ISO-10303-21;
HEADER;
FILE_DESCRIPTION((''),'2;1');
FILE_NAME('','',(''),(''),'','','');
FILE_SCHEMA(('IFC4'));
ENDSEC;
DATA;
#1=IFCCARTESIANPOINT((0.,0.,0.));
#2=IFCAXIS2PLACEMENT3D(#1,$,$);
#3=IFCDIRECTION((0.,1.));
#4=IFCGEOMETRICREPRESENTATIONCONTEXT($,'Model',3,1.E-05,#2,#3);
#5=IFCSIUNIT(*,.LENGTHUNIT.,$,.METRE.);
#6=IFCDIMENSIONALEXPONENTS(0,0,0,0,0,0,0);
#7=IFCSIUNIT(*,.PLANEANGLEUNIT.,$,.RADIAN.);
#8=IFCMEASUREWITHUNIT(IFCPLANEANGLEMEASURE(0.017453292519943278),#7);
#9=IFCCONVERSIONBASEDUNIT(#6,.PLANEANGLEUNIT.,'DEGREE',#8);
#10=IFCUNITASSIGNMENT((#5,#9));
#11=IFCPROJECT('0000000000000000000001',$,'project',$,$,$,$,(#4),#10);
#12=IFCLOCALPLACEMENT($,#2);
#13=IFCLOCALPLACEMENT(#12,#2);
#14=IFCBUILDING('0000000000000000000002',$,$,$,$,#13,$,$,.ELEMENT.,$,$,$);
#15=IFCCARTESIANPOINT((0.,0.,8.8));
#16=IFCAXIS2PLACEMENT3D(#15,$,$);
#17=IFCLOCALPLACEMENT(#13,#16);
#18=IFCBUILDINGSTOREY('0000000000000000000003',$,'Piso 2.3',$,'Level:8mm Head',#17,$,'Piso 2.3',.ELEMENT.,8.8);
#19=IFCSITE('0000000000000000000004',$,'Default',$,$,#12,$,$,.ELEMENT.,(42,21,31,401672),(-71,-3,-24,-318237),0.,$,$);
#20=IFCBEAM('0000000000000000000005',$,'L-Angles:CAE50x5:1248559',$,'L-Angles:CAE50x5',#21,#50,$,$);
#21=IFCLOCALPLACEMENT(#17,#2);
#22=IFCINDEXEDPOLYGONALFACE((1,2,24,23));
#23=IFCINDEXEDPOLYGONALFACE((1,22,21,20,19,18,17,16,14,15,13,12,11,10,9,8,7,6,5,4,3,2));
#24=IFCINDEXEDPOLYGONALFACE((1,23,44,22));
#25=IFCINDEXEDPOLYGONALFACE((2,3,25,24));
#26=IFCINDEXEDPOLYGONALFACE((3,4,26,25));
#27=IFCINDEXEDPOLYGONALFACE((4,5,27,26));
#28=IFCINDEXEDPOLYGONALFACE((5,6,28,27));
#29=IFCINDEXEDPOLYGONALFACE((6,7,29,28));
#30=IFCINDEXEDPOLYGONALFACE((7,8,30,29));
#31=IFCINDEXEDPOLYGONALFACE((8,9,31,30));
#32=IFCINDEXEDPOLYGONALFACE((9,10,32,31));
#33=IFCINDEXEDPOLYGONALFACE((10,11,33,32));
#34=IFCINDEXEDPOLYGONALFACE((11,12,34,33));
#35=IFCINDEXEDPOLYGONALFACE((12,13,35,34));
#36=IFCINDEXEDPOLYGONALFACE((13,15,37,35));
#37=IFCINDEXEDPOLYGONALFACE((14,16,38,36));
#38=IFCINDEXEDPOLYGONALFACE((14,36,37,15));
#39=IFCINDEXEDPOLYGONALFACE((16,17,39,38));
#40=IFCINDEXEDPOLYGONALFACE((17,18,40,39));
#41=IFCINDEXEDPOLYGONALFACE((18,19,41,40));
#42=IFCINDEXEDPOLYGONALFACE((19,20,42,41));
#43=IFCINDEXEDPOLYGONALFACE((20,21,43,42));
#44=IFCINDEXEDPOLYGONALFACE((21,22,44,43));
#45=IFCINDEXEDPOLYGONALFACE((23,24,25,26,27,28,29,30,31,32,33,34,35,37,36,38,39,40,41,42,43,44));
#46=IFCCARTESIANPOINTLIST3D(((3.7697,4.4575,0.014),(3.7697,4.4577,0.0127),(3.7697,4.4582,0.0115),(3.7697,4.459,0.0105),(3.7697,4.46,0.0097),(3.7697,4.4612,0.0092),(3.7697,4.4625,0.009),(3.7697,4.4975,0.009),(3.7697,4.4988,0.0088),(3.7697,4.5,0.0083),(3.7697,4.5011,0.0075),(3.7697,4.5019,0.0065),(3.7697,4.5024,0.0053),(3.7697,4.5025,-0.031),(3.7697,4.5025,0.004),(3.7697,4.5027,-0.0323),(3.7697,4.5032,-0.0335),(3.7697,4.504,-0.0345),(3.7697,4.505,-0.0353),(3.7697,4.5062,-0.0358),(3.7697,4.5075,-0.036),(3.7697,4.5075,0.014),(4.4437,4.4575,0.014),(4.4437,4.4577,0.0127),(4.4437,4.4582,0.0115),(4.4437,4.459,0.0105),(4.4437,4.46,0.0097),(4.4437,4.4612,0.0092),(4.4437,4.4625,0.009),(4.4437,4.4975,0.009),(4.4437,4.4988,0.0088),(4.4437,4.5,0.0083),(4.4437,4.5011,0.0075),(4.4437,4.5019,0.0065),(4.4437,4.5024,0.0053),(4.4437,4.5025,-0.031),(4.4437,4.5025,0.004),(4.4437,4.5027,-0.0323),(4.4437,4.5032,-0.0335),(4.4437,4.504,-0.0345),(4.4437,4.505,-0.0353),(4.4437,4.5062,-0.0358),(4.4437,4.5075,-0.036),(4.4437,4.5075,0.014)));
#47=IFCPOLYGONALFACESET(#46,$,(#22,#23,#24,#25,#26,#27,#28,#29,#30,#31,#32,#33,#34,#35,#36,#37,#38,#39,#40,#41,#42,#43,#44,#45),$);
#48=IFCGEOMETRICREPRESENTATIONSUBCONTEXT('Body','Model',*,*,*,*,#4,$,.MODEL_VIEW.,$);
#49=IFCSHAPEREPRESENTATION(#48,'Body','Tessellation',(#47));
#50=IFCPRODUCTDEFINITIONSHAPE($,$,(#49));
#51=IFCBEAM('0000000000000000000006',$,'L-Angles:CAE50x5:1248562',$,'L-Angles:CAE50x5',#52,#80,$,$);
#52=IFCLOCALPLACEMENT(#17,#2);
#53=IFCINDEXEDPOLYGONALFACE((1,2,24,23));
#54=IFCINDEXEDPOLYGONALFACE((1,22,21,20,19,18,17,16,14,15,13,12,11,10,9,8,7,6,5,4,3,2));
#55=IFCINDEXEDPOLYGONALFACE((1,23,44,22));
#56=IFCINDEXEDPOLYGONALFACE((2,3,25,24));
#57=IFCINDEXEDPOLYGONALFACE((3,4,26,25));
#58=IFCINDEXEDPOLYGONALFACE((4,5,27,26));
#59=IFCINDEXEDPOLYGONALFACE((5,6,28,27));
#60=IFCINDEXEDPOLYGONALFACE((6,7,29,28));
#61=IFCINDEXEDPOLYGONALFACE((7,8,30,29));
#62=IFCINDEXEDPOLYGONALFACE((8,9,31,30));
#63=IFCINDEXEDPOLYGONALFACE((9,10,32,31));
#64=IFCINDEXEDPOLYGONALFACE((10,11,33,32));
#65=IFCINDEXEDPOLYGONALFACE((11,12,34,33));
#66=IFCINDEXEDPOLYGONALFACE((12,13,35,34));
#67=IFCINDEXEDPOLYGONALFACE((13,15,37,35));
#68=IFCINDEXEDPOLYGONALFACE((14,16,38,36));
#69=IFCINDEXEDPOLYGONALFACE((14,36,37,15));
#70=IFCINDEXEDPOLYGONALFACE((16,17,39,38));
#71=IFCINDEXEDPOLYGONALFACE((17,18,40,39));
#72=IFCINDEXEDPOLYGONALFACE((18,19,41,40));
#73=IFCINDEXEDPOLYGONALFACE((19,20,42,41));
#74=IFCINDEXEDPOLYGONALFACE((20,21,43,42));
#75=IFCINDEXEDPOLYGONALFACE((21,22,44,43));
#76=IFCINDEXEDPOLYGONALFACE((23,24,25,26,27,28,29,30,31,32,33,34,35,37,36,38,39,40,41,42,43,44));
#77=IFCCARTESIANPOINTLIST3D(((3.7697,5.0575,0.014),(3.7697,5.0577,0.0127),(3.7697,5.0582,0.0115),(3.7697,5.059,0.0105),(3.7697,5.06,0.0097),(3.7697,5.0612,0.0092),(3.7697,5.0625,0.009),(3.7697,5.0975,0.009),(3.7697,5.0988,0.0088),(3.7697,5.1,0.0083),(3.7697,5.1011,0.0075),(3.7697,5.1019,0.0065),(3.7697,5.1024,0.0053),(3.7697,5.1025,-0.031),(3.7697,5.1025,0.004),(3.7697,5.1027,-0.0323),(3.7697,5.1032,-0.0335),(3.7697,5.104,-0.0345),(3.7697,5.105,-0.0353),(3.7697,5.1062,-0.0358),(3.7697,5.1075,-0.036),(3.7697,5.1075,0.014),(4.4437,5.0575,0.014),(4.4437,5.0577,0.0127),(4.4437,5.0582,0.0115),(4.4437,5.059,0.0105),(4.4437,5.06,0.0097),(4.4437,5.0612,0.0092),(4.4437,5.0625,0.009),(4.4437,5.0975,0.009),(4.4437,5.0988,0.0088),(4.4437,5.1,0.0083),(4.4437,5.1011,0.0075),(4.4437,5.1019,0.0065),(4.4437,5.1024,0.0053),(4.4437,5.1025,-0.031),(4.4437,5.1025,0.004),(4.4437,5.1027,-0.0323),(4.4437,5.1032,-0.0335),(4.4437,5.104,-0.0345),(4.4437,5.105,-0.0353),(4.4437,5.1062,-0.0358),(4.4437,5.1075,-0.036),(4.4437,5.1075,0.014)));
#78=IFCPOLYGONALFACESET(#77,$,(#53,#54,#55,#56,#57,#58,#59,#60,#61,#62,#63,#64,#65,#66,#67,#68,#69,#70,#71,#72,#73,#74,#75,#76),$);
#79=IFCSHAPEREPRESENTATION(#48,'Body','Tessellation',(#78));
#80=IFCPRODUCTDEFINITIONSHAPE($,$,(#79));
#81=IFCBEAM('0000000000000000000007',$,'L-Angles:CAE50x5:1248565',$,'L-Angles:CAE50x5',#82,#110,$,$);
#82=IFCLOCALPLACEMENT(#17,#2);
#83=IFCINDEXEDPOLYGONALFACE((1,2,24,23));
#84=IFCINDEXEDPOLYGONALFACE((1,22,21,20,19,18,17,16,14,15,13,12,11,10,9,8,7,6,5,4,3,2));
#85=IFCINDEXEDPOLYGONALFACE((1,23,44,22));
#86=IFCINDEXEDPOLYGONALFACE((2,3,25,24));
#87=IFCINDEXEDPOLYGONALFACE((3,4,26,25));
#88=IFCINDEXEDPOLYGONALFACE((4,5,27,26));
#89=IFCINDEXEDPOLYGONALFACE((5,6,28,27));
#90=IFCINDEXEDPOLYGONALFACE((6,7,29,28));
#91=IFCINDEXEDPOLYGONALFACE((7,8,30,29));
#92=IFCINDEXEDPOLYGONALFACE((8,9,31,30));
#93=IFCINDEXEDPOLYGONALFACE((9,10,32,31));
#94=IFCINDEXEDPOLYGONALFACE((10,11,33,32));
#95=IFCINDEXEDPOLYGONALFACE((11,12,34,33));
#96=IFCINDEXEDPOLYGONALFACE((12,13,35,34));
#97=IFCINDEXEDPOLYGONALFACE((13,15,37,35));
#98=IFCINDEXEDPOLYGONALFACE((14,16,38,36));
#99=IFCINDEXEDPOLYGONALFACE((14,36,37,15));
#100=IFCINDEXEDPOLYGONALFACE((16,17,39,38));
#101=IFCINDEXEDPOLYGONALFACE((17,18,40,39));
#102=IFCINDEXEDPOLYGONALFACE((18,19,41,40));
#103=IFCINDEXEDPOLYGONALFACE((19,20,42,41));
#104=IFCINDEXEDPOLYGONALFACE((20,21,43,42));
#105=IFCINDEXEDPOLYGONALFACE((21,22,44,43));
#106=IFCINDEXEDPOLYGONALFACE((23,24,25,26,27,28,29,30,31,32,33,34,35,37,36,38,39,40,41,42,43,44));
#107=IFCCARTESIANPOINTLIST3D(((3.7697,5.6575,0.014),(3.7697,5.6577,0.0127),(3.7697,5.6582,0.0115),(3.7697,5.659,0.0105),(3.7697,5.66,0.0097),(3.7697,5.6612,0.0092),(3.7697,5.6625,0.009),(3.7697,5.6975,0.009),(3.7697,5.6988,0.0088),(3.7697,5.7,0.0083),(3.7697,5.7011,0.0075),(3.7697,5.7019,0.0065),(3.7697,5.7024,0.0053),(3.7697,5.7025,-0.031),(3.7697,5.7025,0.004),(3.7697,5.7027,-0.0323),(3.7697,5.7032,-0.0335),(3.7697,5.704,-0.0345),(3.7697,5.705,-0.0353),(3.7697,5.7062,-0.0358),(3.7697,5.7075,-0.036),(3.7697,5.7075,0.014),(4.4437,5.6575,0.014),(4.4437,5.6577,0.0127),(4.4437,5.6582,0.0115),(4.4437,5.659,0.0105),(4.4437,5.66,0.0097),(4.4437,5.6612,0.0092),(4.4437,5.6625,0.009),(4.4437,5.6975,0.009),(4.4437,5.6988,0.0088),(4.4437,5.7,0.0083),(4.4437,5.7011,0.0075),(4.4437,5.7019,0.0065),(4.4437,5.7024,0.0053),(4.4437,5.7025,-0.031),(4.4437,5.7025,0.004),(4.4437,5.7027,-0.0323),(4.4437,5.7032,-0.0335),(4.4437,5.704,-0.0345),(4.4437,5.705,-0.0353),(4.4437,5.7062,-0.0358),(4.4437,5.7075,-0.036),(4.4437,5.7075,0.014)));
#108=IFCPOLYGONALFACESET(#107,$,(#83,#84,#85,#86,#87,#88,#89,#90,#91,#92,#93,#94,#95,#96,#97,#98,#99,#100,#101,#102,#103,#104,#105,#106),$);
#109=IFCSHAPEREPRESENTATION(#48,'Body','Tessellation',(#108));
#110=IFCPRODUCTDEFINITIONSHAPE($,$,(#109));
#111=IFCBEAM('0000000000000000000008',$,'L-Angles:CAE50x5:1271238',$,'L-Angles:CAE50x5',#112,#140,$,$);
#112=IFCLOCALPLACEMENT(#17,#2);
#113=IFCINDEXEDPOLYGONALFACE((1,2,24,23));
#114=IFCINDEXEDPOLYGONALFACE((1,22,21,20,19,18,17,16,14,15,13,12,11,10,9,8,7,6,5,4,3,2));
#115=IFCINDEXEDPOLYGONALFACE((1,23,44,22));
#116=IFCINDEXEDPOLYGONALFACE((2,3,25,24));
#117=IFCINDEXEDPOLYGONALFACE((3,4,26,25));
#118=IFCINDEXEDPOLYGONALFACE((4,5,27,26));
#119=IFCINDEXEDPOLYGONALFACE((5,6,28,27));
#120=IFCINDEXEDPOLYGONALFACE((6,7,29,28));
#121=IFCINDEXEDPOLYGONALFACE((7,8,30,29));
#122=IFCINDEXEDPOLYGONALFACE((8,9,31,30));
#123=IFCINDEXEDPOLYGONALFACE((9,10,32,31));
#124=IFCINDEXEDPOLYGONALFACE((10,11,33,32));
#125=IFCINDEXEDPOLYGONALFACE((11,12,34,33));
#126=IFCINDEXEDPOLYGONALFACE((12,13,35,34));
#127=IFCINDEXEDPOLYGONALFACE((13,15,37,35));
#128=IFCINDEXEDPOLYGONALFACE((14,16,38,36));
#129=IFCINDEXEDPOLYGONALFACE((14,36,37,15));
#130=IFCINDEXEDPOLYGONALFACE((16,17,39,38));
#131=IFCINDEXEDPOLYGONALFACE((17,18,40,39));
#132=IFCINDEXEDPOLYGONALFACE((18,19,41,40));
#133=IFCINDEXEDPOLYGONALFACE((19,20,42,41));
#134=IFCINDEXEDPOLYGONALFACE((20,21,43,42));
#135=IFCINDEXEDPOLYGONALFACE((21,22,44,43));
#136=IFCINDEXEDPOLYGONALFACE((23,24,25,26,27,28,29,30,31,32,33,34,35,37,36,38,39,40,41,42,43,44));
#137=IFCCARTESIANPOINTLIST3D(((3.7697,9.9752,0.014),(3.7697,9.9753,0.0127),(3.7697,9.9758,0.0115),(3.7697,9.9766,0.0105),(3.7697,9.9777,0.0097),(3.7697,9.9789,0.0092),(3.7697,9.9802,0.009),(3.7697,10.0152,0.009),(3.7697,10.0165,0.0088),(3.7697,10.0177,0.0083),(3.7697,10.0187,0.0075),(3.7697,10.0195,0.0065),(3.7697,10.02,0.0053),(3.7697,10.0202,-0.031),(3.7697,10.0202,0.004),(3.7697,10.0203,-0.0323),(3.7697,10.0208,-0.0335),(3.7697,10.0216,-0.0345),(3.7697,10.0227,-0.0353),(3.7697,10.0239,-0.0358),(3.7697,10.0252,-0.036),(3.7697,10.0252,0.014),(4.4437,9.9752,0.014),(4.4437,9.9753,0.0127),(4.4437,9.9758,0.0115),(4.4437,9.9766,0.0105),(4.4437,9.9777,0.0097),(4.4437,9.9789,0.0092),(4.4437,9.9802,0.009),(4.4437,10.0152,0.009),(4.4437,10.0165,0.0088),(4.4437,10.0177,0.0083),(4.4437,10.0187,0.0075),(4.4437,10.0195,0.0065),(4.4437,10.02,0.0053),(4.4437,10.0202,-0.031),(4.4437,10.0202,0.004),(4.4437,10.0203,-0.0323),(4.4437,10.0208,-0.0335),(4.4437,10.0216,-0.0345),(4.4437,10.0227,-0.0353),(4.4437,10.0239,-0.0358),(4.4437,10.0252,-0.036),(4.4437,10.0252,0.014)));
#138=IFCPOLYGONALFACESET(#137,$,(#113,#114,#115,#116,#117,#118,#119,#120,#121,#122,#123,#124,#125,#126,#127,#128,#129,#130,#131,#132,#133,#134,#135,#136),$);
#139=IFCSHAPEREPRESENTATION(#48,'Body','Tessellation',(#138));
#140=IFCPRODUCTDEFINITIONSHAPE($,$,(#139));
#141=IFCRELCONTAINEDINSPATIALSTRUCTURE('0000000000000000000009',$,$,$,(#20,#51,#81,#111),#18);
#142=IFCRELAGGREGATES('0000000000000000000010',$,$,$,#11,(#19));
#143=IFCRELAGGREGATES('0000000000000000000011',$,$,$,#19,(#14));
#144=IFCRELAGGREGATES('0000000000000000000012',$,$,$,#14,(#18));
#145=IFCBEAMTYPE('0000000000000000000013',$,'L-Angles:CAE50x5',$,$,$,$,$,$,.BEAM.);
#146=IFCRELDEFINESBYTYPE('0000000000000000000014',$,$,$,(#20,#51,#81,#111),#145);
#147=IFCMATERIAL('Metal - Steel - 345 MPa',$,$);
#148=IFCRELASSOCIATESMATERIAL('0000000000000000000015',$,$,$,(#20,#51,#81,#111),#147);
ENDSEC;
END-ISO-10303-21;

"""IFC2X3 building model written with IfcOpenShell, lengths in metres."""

from ifc_helpers import new_model, entity, si_unit, converted_unit, direction, frame, frame_2d, origin, place, context, subcontext, project, spatial, polyline, circle_curve, parameter, trimmed, segment, composite_curve, outline, extrude, material, type_object, element, save


model = new_model("IFC2X3")

# Units and contexts
model_context = context("Model", 3, precision=1e-05, world=origin(), true_north=direction((0.0, 1.0)))
body_context = subcontext(model_context, "Body", "Model", "MODEL_VIEW")
ifc_project = project(units=[si_unit("LENGTHUNIT", "METRE"), converted_unit("PLANEANGLEUNIT", "DEGREE", entity("IfcPlaneAngleMeasure", 0.017453292519943278), si_unit("PLANEANGLEUNIT", "RADIAN"), dimensions=[0, 0, 0, 0, 0, 0, 0])], contexts=[model_context])

# Site, building, storey
site_placement = place(None, origin())
site = spatial("IfcSite", under=ifc_project, at=site_placement, Name="Default", CompositionType="ELEMENT", RefLatitude=(42, 21, 31, 401672), RefLongitude=(-71, -3, -24, -318237), RefElevation=0.0)
building_placement = place(site_placement, origin())
building = spatial("IfcBuilding", under=site, at=building_placement, CompositionType="ELEMENT")
storey_placement = place(building_placement, frame((0.0, 0.0, 8.8)))
storey = spatial("IfcBuildingStorey", under=building, at=storey_placement, Name="Piso 2.3", ObjectType="Level:8mm Head", LongName="Piso 2.3", CompositionType="ELEMENT", Elevation=8.8)

# Shared definitions
ifc_material = material(Name="Metal - Steel - 345 MPa")

# Beams
beam_type_1 = type_object("IfcBeamType", Name="L-Angles:CAE50x5", PredefinedType="BEAM")
beam_1_placement = place(storey_placement, frame((3.7067, 4.4935, 0.0)))
element("IfcBeam", 1, at=beam_1_placement, inside=storey, type_object=beam_type_1, material=ifc_material, Name="L-Angles:CAE50x5:1248559", ObjectType="L-Angles:CAE50x5", context=body_context, shape_type="SweptSolid", body=[
    extrude(outline(composite_curve([segment(polyline([(-0.0336, -0.0164), (0.0164, -0.0164)]), True, "CONTINUOUS"), segment(polyline([(0.0164, -0.0164), (0.0164, 0.0336)]), True, "CONTINUOUS"), segment(trimmed(circle_curve(frame_2d((0.0164, 0.0286), x_axis=(0.0, 1.0)), 0.005), [parameter(0.0)], [parameter(90.0)], True, "PARAMETER"), True, "CONTINUOUS"), segment(polyline([(0.0114, 0.0286), (0.0114, -0.0064)]), True, "CONTINUOUS"), segment(trimmed(circle_curve(frame_2d((0.0064, -0.0064), x_axis=(1.0, 0.0)), 0.005), [parameter(270.0)], [parameter(0.0)], True, "PARAMETER"), False, "CONTINUOUS"), segment(polyline([(0.0064, -0.0114), (-0.0286, -0.0114)]), True, "CONTINUOUS"), segment(trimmed(circle_curve(frame_2d((-0.0286, -0.0164), x_axis=(0.0, 1.0)), 0.005), [parameter(0.0)], [parameter(90.0)], True, "PARAMETER"), True, "CONTINUOUS")], self_intersect=False)), frame((0.063, -0.0024, -0.0024), z_axis=(1.0, 0.0, 0.0), x_axis=(0.0, 0.0, 1.0)), (0.0, 0.0, 1.0), 0.674),
])
beam_2_placement = place(storey_placement, frame((3.7067, 5.0935, 0.0)))
element("IfcBeam", 2, at=beam_2_placement, inside=storey, type_object=beam_type_1, material=ifc_material, Name="L-Angles:CAE50x5:1248562", ObjectType="L-Angles:CAE50x5", context=body_context, shape_type="SweptSolid", body=[
    extrude(outline(composite_curve([segment(polyline([(-0.0336, -0.0164), (0.0164, -0.0164)]), True, "CONTINUOUS"), segment(polyline([(0.0164, -0.0164), (0.0164, 0.0336)]), True, "CONTINUOUS"), segment(trimmed(circle_curve(frame_2d((0.0164, 0.0286), x_axis=(0.0, 1.0)), 0.005), [parameter(0.0)], [parameter(90.0)], True, "PARAMETER"), True, "CONTINUOUS"), segment(polyline([(0.0114, 0.0286), (0.0114, -0.0064)]), True, "CONTINUOUS"), segment(trimmed(circle_curve(frame_2d((0.0064, -0.0064), x_axis=(1.0, 0.0)), 0.005), [parameter(270.0)], [parameter(0.0)], True, "PARAMETER"), False, "CONTINUOUS"), segment(polyline([(0.0064, -0.0114), (-0.0286, -0.0114)]), True, "CONTINUOUS"), segment(trimmed(circle_curve(frame_2d((-0.0286, -0.0164), x_axis=(0.0, 1.0)), 0.005), [parameter(0.0)], [parameter(90.0)], True, "PARAMETER"), True, "CONTINUOUS")], self_intersect=False)), frame((0.063, -0.0024, -0.0024), z_axis=(1.0, 0.0, 0.0), x_axis=(0.0, 0.0, 1.0)), (0.0, 0.0, 1.0), 0.674),
])
beam_3_placement = place(storey_placement, frame((3.7067, 5.6935, 0.0)))
element("IfcBeam", 3, at=beam_3_placement, inside=storey, type_object=beam_type_1, material=ifc_material, Name="L-Angles:CAE50x5:1248565", ObjectType="L-Angles:CAE50x5", context=body_context, shape_type="SweptSolid", body=[
    extrude(outline(composite_curve([segment(polyline([(-0.0336, -0.0164), (0.0164, -0.0164)]), True, "CONTINUOUS"), segment(polyline([(0.0164, -0.0164), (0.0164, 0.0336)]), True, "CONTINUOUS"), segment(trimmed(circle_curve(frame_2d((0.0164, 0.0286), x_axis=(0.0, 1.0)), 0.005), [parameter(0.0)], [parameter(90.0)], True, "PARAMETER"), True, "CONTINUOUS"), segment(polyline([(0.0114, 0.0286), (0.0114, -0.0064)]), True, "CONTINUOUS"), segment(trimmed(circle_curve(frame_2d((0.0064, -0.0064), x_axis=(1.0, 0.0)), 0.005), [parameter(270.0)], [parameter(0.0)], True, "PARAMETER"), False, "CONTINUOUS"), segment(polyline([(0.0064, -0.0114), (-0.0286, -0.0114)]), True, "CONTINUOUS"), segment(trimmed(circle_curve(frame_2d((-0.0286, -0.0164), x_axis=(0.0, 1.0)), 0.005), [parameter(0.0)], [parameter(90.0)], True, "PARAMETER"), True, "CONTINUOUS")], self_intersect=False)), frame((0.063, -0.0024, -0.0024), z_axis=(1.0, 0.0, 0.0), x_axis=(0.0, 0.0, 1.0)), (0.0, 0.0, 1.0), 0.674),
])
beam_4_placement = place(storey_placement, frame((3.7067, 10.0112, 0.0)))
element("IfcBeam", 4, at=beam_4_placement, inside=storey, type_object=beam_type_1, material=ifc_material, Name="L-Angles:CAE50x5:1271238", ObjectType="L-Angles:CAE50x5", context=body_context, shape_type="SweptSolid", body=[
    extrude(outline(composite_curve([segment(polyline([(-0.0336, -0.0164), (0.0164, -0.0164)]), True, "CONTINUOUS"), segment(polyline([(0.0164, -0.0164), (0.0164, 0.0336)]), True, "CONTINUOUS"), segment(trimmed(circle_curve(frame_2d((0.0164, 0.0286), x_axis=(0.0, 1.0)), 0.005), [parameter(0.0)], [parameter(90.0)], True, "PARAMETER"), True, "CONTINUOUS"), segment(polyline([(0.0114, 0.0286), (0.0114, -0.0064)]), True, "CONTINUOUS"), segment(trimmed(circle_curve(frame_2d((0.0064, -0.0064), x_axis=(1.0, 0.0)), 0.005), [parameter(270.0)], [parameter(0.0)], True, "PARAMETER"), False, "CONTINUOUS"), segment(polyline([(0.0064, -0.0114), (-0.0286, -0.0114)]), True, "CONTINUOUS"), segment(trimmed(circle_curve(frame_2d((-0.0286, -0.0164), x_axis=(0.0, 1.0)), 0.005), [parameter(0.0)], [parameter(90.0)], True, "PARAMETER"), True, "CONTINUOUS")], self_intersect=False)), frame((0.063, -0.0024, -0.0024), z_axis=(1.0, 0.0, 0.0), x_axis=(0.0, 0.0, 1.0)), (0.0, 0.0, 1.0), 0.674),
])

save(model, "model.ifc")
